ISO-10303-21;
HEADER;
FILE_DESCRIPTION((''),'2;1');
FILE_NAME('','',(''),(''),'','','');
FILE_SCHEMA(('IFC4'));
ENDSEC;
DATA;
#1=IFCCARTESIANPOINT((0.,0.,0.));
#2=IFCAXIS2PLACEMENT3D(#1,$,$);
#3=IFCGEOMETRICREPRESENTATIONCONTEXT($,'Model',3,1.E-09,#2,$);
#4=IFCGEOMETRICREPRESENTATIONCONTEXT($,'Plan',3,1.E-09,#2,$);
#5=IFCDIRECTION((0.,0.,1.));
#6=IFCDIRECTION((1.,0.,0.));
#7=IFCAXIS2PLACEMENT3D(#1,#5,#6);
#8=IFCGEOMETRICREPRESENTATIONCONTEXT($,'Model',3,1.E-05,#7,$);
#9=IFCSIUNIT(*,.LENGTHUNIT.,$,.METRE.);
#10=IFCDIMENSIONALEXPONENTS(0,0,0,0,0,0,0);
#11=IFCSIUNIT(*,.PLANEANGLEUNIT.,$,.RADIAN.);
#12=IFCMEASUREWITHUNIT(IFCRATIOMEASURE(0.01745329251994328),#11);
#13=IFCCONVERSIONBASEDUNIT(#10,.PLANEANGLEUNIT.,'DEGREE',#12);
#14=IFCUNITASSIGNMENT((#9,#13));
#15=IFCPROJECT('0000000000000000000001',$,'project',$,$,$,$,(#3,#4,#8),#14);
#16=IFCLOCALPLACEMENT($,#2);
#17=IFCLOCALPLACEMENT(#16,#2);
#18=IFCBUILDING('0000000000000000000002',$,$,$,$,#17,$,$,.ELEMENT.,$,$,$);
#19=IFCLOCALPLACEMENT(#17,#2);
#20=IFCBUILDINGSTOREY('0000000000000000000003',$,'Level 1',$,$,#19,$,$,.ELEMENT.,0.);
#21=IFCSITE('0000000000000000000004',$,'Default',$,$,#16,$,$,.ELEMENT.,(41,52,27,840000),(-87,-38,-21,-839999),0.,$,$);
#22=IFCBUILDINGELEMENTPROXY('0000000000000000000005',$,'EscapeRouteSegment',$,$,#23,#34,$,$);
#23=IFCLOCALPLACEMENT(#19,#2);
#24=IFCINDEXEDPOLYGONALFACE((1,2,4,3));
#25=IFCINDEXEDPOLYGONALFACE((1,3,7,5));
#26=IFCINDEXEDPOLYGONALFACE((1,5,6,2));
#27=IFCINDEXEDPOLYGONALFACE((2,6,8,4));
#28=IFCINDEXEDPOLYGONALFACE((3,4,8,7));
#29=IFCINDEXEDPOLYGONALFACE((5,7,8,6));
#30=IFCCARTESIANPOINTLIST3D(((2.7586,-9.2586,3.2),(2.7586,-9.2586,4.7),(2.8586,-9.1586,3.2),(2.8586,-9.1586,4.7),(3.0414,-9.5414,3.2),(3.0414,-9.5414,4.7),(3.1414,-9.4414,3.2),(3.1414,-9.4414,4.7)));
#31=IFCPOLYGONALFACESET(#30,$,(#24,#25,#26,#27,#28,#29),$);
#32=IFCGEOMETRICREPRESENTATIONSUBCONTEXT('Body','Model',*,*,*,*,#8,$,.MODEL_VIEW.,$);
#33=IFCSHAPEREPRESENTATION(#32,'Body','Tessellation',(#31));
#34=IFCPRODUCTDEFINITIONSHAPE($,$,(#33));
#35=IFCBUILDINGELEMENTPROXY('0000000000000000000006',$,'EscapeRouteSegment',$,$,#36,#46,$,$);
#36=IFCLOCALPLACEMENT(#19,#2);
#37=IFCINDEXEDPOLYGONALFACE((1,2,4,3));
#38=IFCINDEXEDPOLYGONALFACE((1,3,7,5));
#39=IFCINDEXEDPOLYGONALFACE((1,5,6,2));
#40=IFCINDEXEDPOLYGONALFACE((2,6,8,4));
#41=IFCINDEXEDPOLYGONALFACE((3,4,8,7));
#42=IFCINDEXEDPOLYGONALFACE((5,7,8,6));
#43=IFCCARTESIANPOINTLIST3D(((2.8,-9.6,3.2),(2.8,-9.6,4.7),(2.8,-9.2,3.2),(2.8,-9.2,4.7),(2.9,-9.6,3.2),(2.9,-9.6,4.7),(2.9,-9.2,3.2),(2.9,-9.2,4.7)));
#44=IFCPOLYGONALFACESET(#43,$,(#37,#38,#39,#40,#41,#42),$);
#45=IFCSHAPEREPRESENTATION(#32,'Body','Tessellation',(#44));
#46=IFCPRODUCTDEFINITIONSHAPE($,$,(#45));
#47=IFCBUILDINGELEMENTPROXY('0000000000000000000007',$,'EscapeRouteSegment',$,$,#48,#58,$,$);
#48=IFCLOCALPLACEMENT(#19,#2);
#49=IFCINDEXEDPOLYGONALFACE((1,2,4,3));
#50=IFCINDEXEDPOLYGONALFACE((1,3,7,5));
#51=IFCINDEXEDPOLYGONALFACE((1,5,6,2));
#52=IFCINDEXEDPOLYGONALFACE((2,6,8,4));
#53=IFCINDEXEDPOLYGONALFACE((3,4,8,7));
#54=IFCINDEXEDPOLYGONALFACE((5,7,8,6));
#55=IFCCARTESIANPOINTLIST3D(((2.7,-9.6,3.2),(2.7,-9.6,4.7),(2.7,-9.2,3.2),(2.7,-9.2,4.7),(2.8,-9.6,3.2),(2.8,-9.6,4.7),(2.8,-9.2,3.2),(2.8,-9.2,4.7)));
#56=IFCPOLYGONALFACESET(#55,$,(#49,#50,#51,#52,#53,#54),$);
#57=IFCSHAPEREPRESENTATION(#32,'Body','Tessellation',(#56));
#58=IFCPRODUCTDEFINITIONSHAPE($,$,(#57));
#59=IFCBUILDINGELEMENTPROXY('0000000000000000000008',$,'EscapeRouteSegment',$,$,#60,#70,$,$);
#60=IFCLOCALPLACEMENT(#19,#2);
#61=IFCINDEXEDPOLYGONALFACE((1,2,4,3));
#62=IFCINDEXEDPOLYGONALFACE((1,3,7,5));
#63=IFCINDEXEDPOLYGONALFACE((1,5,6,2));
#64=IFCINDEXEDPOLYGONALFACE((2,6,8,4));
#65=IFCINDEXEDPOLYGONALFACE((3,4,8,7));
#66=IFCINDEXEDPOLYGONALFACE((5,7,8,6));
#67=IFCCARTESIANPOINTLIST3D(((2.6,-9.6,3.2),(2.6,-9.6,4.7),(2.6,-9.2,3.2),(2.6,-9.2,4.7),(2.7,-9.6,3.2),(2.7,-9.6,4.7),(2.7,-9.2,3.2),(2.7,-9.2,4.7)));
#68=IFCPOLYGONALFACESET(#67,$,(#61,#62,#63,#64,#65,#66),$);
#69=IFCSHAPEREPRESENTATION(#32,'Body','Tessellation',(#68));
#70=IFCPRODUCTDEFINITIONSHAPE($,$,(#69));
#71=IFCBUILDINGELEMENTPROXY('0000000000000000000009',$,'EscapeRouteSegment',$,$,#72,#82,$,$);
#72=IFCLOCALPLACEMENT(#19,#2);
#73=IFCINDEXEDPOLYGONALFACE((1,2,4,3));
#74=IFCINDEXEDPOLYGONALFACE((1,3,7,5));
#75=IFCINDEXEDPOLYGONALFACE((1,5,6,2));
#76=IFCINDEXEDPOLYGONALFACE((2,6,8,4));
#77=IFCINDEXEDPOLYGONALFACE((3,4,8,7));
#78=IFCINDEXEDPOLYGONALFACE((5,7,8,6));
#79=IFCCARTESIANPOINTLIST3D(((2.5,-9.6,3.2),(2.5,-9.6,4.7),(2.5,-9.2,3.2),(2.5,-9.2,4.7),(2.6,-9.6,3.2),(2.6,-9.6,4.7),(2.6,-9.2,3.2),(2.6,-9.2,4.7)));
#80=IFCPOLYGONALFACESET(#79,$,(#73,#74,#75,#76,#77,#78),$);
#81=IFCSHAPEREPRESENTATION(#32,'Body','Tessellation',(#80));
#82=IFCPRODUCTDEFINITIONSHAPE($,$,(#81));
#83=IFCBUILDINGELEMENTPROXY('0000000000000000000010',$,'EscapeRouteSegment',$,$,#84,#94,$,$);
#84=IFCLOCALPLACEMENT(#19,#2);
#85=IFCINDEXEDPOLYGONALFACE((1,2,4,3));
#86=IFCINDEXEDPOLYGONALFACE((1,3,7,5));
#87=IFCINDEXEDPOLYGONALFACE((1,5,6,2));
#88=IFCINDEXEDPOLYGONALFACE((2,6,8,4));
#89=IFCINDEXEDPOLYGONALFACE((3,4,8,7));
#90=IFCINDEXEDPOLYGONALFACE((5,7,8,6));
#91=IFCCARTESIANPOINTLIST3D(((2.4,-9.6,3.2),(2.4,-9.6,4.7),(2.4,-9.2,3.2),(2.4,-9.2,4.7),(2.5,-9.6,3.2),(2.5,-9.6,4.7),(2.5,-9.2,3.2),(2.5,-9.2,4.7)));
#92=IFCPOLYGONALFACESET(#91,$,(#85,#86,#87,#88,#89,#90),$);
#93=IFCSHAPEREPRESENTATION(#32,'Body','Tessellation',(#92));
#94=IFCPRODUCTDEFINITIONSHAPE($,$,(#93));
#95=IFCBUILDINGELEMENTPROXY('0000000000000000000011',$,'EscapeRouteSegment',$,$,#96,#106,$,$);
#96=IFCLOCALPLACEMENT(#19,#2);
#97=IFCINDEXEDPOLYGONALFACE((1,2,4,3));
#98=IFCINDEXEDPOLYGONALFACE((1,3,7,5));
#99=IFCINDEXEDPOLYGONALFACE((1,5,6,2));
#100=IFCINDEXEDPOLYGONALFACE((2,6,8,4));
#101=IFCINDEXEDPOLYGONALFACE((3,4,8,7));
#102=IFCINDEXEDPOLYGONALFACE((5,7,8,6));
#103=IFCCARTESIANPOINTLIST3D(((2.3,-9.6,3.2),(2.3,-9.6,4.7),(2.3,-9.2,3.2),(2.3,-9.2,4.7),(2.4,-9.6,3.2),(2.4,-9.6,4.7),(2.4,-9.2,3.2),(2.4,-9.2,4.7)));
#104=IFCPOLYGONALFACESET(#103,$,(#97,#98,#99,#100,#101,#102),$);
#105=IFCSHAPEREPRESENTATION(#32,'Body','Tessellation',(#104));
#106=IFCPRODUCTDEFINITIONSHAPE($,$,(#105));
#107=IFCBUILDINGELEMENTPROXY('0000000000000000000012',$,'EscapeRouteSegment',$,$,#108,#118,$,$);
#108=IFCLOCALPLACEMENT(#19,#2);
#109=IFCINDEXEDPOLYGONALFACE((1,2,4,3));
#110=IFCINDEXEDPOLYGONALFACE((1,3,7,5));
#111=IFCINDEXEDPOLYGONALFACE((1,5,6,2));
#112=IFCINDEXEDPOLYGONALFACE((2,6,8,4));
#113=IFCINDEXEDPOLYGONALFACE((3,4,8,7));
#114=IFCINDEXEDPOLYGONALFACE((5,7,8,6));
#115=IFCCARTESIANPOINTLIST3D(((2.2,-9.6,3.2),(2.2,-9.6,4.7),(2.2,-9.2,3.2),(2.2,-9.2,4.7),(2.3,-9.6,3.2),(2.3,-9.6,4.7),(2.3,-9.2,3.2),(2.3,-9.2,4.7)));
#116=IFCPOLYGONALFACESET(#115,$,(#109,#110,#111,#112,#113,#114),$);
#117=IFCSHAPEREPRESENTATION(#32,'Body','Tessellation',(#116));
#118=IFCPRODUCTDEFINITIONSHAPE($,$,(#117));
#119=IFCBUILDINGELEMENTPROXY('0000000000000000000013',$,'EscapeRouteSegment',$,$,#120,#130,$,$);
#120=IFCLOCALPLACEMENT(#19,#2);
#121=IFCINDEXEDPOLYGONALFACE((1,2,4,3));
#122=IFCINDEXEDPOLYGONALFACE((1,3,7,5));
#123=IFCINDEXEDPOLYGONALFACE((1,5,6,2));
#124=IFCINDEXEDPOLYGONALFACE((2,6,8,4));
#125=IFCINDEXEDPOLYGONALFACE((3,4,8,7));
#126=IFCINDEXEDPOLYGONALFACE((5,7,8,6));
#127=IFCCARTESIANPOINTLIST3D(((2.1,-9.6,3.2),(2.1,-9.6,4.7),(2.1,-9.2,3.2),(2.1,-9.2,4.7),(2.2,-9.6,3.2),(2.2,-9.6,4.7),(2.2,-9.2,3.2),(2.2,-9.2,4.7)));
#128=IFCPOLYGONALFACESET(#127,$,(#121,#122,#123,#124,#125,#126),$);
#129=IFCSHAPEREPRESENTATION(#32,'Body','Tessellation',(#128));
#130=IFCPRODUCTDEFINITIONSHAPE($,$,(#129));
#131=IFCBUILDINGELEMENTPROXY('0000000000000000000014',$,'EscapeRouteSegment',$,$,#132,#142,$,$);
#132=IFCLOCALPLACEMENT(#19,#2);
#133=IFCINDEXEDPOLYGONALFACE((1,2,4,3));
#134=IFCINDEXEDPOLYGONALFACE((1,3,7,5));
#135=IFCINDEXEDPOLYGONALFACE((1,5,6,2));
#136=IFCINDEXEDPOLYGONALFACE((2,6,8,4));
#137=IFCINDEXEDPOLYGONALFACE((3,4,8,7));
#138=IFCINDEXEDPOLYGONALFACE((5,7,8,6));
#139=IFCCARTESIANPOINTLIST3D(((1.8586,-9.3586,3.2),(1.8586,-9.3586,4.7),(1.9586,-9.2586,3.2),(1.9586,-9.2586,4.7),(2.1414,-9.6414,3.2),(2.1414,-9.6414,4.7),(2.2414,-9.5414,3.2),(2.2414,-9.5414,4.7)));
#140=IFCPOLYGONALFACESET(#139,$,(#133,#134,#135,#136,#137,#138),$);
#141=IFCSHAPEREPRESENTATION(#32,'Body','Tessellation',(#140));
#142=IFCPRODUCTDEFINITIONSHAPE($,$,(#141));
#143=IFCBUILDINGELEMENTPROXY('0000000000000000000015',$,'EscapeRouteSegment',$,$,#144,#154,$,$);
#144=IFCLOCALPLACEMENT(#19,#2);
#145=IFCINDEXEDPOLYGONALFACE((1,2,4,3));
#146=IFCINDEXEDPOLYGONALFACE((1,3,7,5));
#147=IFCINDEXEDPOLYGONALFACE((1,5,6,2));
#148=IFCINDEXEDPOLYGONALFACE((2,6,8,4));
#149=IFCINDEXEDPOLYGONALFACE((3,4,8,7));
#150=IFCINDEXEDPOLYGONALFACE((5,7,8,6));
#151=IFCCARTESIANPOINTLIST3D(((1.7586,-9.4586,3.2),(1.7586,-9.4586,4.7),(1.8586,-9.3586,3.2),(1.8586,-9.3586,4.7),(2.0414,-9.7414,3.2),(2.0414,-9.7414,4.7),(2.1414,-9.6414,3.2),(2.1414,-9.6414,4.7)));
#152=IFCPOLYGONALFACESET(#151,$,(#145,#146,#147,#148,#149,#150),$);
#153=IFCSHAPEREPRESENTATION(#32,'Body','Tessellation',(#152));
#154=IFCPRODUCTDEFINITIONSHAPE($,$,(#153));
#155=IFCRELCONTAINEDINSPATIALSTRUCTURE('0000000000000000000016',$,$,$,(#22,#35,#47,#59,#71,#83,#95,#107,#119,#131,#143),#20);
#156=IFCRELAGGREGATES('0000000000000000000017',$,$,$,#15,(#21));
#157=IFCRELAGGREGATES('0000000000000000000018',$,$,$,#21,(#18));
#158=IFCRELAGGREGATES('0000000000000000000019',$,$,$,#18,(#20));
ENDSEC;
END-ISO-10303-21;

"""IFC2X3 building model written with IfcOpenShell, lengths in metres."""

from ifc_helpers import new_model, entity, si_unit, converted_unit, frame, origin, origin_with_axes, place, context, subcontext, project, spatial, polyline, outline, extrude, element, save


model = new_model("IFC2X3")

# Units and contexts
model_context_1 = context("Model", 3, precision=1e-09, world=origin())
plan_context = context("Plan", 3, precision=1e-09, world=origin())
model_context_2 = context("Model", 3, precision=1e-05, world=origin_with_axes())
body_context = subcontext(model_context_2, "Body", "Model", "MODEL_VIEW")
ifc_project = project(units=[si_unit("LENGTHUNIT", "METRE"), converted_unit("PLANEANGLEUNIT", "DEGREE", entity("IfcRatioMeasure", 0.01745329251994328), si_unit("PLANEANGLEUNIT", "RADIAN"), dimensions=[0, 0, 0, 0, 0, 0, 0])], contexts=[model_context_1, plan_context, model_context_2])

# Site, building, storey
site_placement = place(None, origin())
site = spatial("IfcSite", under=ifc_project, at=site_placement, Name="Default", CompositionType="ELEMENT", RefLatitude=(41, 52, 27, 840000), RefLongitude=(-87, -38, -21, -839999), RefElevation=0.0)
building_placement = place(site_placement, origin())
building = spatial("IfcBuilding", under=site, at=building_placement, CompositionType="ELEMENT")
storey_placement = place(building_placement, origin())
storey = spatial("IfcBuildingStorey", under=building, at=storey_placement, Name="Level 1", CompositionType="ELEMENT", Elevation=0.0)

# Building element proxies
proxy_1_placement = place(storey_placement, frame((3.0, -9.3, 3.2), z_axis=(0.0, 0.0, 1.0), x_axis=(-0.707108, -0.707105, 0.0)))
element("IfcBuildingElementProxy", 1, at=proxy_1_placement, inside=storey, Name="EscapeRouteSegment", context=body_context, shape_type="SweptSolid", body=[
    extrude(outline(polyline([(0.0, -0.2), (0.0, 0.2), (0.1414, 0.2), (0.1414, -0.2), (0.0, -0.2)])), origin_with_axes(), (0.0, 0.0, 1.0), 1.5),
])
proxy_2_placement = place(storey_placement, frame((2.9, -9.4, 3.2), z_axis=(0.0, 0.0, 1.0), x_axis=(-1.0, 0.0, 0.0)))
element("IfcBuildingElementProxy", 2, at=proxy_2_placement, inside=storey, Name="EscapeRouteSegment", context=body_context, shape_type="SweptSolid", body=[
    extrude(outline(polyline([(0.0, -0.2), (0.0, 0.2), (0.1, 0.2), (0.1, -0.2), (0.0, -0.2)])), origin_with_axes(), (0.0, 0.0, 1.0), 1.5),
])
proxy_3_placement = place(storey_placement, frame((2.8, -9.4, 3.2), z_axis=(0.0, 0.0, 1.0), x_axis=(-1.0, 0.0, 0.0)))
element("IfcBuildingElementProxy", 3, at=proxy_3_placement, inside=storey, Name="EscapeRouteSegment", context=body_context, shape_type="SweptSolid", body=[
    extrude(outline(polyline([(0.0, -0.2), (0.0, 0.2), (0.1, 0.2), (0.1, -0.2), (0.0, -0.2)])), origin_with_axes(), (0.0, 0.0, 1.0), 1.5),
])
proxy_4_placement = place(storey_placement, frame((2.7, -9.4, 3.2), z_axis=(0.0, 0.0, 1.0), x_axis=(-1.0, 0.0, 0.0)))
element("IfcBuildingElementProxy", 4, at=proxy_4_placement, inside=storey, Name="EscapeRouteSegment", context=body_context, shape_type="SweptSolid", body=[
    extrude(outline(polyline([(0.0, -0.2), (0.0, 0.2), (0.1, 0.2), (0.1, -0.2), (0.0, -0.2)])), origin_with_axes(), (0.0, 0.0, 1.0), 1.5),
])
for number, where, z_axis, x_axis, name in (
    (5, (2.6, -9.4, 3.2), (0.0, 0.0, 1.0), (-1.0, 0.0, 0.0), "EscapeRouteSegment"),
    (6, (2.5, -9.4, 3.2), (0.0, 0.0, 1.0), (-1.0, 0.0, 0.0), "EscapeRouteSegment"),
):
    element("IfcBuildingElementProxy", number, at=place(storey_placement, frame(where, z_axis=z_axis, x_axis=x_axis)), inside=storey, Name=name, context=body_context, shape_type="SweptSolid", body=[
        extrude(outline(polyline([(0.0, -0.2), (0.0, 0.2), (0.1, 0.2), (0.1, -0.2), (0.0, -0.2)])), origin_with_axes(), (0.0, 0.0, 1.0), 1.5),
    ])
proxy_5_placement = place(storey_placement, frame((2.4, -9.4, 3.2), z_axis=(0.0, 0.0, 1.0), x_axis=(-1.0, 0.0, 0.0)))
element("IfcBuildingElementProxy", 7, at=proxy_5_placement, inside=storey, Name="EscapeRouteSegment", context=body_context, shape_type="SweptSolid", body=[
    extrude(outline(polyline([(0.0, -0.2), (0.0, 0.2), (0.1, 0.2), (0.1, -0.2), (0.0, -0.2)])), origin_with_axes(), (0.0, 0.0, 1.0), 1.5),
])
proxy_6_placement = place(storey_placement, frame((2.3, -9.4, 3.2), z_axis=(0.0, 0.0, 1.0), x_axis=(-1.0, 0.0, 0.0)))
element("IfcBuildingElementProxy", 8, at=proxy_6_placement, inside=storey, Name="EscapeRouteSegment", context=body_context, shape_type="SweptSolid", body=[
    extrude(outline(polyline([(0.0, -0.2), (0.0, 0.2), (0.1, 0.2), (0.1, -0.2), (0.0, -0.2)])), origin_with_axes(), (0.0, 0.0, 1.0), 1.5),
])
proxy_7_placement = place(storey_placement, frame((2.2, -9.4, 3.2), z_axis=(0.0, 0.0, 1.0), x_axis=(-1.0, 0.0, 0.0)))
element("IfcBuildingElementProxy", 9, at=proxy_7_placement, inside=storey, Name="EscapeRouteSegment", context=body_context, shape_type="SweptSolid", body=[
    extrude(outline(polyline([(0.0, -0.2), (0.0, 0.2), (0.1, 0.2), (0.1, -0.2), (0.0, -0.2)])), origin_with_axes(), (0.0, 0.0, 1.0), 1.5),
])
proxy_8_placement = place(storey_placement, frame((2.1, -9.4, 3.2), z_axis=(0.0, 0.0, 1.0), x_axis=(-0.707105, -0.707108, 0.0)))
element("IfcBuildingElementProxy", 10, at=proxy_8_placement, inside=storey, Name="EscapeRouteSegment", context=body_context, shape_type="SweptSolid", body=[
    extrude(outline(polyline([(0.0, -0.2), (0.0, 0.2), (0.1414, 0.2), (0.1414, -0.2), (0.0, -0.2)])), origin_with_axes(), (0.0, 0.0, 1.0), 1.5),
])
proxy_9_placement = place(storey_placement, frame((2.0, -9.5, 3.2), z_axis=(0.0, 0.0, 1.0), x_axis=(-0.707105, -0.707108, 0.0)))
element("IfcBuildingElementProxy", 11, at=proxy_9_placement, inside=storey, Name="EscapeRouteSegment", context=body_context, shape_type="SweptSolid", body=[
    extrude(outline(polyline([(0.0, -0.2), (0.0, 0.2), (0.1414, 0.2), (0.1414, -0.2), (0.0, -0.2)])), origin_with_axes(), (0.0, 0.0, 1.0), 1.5),
])

save(model, "model.ifc")
